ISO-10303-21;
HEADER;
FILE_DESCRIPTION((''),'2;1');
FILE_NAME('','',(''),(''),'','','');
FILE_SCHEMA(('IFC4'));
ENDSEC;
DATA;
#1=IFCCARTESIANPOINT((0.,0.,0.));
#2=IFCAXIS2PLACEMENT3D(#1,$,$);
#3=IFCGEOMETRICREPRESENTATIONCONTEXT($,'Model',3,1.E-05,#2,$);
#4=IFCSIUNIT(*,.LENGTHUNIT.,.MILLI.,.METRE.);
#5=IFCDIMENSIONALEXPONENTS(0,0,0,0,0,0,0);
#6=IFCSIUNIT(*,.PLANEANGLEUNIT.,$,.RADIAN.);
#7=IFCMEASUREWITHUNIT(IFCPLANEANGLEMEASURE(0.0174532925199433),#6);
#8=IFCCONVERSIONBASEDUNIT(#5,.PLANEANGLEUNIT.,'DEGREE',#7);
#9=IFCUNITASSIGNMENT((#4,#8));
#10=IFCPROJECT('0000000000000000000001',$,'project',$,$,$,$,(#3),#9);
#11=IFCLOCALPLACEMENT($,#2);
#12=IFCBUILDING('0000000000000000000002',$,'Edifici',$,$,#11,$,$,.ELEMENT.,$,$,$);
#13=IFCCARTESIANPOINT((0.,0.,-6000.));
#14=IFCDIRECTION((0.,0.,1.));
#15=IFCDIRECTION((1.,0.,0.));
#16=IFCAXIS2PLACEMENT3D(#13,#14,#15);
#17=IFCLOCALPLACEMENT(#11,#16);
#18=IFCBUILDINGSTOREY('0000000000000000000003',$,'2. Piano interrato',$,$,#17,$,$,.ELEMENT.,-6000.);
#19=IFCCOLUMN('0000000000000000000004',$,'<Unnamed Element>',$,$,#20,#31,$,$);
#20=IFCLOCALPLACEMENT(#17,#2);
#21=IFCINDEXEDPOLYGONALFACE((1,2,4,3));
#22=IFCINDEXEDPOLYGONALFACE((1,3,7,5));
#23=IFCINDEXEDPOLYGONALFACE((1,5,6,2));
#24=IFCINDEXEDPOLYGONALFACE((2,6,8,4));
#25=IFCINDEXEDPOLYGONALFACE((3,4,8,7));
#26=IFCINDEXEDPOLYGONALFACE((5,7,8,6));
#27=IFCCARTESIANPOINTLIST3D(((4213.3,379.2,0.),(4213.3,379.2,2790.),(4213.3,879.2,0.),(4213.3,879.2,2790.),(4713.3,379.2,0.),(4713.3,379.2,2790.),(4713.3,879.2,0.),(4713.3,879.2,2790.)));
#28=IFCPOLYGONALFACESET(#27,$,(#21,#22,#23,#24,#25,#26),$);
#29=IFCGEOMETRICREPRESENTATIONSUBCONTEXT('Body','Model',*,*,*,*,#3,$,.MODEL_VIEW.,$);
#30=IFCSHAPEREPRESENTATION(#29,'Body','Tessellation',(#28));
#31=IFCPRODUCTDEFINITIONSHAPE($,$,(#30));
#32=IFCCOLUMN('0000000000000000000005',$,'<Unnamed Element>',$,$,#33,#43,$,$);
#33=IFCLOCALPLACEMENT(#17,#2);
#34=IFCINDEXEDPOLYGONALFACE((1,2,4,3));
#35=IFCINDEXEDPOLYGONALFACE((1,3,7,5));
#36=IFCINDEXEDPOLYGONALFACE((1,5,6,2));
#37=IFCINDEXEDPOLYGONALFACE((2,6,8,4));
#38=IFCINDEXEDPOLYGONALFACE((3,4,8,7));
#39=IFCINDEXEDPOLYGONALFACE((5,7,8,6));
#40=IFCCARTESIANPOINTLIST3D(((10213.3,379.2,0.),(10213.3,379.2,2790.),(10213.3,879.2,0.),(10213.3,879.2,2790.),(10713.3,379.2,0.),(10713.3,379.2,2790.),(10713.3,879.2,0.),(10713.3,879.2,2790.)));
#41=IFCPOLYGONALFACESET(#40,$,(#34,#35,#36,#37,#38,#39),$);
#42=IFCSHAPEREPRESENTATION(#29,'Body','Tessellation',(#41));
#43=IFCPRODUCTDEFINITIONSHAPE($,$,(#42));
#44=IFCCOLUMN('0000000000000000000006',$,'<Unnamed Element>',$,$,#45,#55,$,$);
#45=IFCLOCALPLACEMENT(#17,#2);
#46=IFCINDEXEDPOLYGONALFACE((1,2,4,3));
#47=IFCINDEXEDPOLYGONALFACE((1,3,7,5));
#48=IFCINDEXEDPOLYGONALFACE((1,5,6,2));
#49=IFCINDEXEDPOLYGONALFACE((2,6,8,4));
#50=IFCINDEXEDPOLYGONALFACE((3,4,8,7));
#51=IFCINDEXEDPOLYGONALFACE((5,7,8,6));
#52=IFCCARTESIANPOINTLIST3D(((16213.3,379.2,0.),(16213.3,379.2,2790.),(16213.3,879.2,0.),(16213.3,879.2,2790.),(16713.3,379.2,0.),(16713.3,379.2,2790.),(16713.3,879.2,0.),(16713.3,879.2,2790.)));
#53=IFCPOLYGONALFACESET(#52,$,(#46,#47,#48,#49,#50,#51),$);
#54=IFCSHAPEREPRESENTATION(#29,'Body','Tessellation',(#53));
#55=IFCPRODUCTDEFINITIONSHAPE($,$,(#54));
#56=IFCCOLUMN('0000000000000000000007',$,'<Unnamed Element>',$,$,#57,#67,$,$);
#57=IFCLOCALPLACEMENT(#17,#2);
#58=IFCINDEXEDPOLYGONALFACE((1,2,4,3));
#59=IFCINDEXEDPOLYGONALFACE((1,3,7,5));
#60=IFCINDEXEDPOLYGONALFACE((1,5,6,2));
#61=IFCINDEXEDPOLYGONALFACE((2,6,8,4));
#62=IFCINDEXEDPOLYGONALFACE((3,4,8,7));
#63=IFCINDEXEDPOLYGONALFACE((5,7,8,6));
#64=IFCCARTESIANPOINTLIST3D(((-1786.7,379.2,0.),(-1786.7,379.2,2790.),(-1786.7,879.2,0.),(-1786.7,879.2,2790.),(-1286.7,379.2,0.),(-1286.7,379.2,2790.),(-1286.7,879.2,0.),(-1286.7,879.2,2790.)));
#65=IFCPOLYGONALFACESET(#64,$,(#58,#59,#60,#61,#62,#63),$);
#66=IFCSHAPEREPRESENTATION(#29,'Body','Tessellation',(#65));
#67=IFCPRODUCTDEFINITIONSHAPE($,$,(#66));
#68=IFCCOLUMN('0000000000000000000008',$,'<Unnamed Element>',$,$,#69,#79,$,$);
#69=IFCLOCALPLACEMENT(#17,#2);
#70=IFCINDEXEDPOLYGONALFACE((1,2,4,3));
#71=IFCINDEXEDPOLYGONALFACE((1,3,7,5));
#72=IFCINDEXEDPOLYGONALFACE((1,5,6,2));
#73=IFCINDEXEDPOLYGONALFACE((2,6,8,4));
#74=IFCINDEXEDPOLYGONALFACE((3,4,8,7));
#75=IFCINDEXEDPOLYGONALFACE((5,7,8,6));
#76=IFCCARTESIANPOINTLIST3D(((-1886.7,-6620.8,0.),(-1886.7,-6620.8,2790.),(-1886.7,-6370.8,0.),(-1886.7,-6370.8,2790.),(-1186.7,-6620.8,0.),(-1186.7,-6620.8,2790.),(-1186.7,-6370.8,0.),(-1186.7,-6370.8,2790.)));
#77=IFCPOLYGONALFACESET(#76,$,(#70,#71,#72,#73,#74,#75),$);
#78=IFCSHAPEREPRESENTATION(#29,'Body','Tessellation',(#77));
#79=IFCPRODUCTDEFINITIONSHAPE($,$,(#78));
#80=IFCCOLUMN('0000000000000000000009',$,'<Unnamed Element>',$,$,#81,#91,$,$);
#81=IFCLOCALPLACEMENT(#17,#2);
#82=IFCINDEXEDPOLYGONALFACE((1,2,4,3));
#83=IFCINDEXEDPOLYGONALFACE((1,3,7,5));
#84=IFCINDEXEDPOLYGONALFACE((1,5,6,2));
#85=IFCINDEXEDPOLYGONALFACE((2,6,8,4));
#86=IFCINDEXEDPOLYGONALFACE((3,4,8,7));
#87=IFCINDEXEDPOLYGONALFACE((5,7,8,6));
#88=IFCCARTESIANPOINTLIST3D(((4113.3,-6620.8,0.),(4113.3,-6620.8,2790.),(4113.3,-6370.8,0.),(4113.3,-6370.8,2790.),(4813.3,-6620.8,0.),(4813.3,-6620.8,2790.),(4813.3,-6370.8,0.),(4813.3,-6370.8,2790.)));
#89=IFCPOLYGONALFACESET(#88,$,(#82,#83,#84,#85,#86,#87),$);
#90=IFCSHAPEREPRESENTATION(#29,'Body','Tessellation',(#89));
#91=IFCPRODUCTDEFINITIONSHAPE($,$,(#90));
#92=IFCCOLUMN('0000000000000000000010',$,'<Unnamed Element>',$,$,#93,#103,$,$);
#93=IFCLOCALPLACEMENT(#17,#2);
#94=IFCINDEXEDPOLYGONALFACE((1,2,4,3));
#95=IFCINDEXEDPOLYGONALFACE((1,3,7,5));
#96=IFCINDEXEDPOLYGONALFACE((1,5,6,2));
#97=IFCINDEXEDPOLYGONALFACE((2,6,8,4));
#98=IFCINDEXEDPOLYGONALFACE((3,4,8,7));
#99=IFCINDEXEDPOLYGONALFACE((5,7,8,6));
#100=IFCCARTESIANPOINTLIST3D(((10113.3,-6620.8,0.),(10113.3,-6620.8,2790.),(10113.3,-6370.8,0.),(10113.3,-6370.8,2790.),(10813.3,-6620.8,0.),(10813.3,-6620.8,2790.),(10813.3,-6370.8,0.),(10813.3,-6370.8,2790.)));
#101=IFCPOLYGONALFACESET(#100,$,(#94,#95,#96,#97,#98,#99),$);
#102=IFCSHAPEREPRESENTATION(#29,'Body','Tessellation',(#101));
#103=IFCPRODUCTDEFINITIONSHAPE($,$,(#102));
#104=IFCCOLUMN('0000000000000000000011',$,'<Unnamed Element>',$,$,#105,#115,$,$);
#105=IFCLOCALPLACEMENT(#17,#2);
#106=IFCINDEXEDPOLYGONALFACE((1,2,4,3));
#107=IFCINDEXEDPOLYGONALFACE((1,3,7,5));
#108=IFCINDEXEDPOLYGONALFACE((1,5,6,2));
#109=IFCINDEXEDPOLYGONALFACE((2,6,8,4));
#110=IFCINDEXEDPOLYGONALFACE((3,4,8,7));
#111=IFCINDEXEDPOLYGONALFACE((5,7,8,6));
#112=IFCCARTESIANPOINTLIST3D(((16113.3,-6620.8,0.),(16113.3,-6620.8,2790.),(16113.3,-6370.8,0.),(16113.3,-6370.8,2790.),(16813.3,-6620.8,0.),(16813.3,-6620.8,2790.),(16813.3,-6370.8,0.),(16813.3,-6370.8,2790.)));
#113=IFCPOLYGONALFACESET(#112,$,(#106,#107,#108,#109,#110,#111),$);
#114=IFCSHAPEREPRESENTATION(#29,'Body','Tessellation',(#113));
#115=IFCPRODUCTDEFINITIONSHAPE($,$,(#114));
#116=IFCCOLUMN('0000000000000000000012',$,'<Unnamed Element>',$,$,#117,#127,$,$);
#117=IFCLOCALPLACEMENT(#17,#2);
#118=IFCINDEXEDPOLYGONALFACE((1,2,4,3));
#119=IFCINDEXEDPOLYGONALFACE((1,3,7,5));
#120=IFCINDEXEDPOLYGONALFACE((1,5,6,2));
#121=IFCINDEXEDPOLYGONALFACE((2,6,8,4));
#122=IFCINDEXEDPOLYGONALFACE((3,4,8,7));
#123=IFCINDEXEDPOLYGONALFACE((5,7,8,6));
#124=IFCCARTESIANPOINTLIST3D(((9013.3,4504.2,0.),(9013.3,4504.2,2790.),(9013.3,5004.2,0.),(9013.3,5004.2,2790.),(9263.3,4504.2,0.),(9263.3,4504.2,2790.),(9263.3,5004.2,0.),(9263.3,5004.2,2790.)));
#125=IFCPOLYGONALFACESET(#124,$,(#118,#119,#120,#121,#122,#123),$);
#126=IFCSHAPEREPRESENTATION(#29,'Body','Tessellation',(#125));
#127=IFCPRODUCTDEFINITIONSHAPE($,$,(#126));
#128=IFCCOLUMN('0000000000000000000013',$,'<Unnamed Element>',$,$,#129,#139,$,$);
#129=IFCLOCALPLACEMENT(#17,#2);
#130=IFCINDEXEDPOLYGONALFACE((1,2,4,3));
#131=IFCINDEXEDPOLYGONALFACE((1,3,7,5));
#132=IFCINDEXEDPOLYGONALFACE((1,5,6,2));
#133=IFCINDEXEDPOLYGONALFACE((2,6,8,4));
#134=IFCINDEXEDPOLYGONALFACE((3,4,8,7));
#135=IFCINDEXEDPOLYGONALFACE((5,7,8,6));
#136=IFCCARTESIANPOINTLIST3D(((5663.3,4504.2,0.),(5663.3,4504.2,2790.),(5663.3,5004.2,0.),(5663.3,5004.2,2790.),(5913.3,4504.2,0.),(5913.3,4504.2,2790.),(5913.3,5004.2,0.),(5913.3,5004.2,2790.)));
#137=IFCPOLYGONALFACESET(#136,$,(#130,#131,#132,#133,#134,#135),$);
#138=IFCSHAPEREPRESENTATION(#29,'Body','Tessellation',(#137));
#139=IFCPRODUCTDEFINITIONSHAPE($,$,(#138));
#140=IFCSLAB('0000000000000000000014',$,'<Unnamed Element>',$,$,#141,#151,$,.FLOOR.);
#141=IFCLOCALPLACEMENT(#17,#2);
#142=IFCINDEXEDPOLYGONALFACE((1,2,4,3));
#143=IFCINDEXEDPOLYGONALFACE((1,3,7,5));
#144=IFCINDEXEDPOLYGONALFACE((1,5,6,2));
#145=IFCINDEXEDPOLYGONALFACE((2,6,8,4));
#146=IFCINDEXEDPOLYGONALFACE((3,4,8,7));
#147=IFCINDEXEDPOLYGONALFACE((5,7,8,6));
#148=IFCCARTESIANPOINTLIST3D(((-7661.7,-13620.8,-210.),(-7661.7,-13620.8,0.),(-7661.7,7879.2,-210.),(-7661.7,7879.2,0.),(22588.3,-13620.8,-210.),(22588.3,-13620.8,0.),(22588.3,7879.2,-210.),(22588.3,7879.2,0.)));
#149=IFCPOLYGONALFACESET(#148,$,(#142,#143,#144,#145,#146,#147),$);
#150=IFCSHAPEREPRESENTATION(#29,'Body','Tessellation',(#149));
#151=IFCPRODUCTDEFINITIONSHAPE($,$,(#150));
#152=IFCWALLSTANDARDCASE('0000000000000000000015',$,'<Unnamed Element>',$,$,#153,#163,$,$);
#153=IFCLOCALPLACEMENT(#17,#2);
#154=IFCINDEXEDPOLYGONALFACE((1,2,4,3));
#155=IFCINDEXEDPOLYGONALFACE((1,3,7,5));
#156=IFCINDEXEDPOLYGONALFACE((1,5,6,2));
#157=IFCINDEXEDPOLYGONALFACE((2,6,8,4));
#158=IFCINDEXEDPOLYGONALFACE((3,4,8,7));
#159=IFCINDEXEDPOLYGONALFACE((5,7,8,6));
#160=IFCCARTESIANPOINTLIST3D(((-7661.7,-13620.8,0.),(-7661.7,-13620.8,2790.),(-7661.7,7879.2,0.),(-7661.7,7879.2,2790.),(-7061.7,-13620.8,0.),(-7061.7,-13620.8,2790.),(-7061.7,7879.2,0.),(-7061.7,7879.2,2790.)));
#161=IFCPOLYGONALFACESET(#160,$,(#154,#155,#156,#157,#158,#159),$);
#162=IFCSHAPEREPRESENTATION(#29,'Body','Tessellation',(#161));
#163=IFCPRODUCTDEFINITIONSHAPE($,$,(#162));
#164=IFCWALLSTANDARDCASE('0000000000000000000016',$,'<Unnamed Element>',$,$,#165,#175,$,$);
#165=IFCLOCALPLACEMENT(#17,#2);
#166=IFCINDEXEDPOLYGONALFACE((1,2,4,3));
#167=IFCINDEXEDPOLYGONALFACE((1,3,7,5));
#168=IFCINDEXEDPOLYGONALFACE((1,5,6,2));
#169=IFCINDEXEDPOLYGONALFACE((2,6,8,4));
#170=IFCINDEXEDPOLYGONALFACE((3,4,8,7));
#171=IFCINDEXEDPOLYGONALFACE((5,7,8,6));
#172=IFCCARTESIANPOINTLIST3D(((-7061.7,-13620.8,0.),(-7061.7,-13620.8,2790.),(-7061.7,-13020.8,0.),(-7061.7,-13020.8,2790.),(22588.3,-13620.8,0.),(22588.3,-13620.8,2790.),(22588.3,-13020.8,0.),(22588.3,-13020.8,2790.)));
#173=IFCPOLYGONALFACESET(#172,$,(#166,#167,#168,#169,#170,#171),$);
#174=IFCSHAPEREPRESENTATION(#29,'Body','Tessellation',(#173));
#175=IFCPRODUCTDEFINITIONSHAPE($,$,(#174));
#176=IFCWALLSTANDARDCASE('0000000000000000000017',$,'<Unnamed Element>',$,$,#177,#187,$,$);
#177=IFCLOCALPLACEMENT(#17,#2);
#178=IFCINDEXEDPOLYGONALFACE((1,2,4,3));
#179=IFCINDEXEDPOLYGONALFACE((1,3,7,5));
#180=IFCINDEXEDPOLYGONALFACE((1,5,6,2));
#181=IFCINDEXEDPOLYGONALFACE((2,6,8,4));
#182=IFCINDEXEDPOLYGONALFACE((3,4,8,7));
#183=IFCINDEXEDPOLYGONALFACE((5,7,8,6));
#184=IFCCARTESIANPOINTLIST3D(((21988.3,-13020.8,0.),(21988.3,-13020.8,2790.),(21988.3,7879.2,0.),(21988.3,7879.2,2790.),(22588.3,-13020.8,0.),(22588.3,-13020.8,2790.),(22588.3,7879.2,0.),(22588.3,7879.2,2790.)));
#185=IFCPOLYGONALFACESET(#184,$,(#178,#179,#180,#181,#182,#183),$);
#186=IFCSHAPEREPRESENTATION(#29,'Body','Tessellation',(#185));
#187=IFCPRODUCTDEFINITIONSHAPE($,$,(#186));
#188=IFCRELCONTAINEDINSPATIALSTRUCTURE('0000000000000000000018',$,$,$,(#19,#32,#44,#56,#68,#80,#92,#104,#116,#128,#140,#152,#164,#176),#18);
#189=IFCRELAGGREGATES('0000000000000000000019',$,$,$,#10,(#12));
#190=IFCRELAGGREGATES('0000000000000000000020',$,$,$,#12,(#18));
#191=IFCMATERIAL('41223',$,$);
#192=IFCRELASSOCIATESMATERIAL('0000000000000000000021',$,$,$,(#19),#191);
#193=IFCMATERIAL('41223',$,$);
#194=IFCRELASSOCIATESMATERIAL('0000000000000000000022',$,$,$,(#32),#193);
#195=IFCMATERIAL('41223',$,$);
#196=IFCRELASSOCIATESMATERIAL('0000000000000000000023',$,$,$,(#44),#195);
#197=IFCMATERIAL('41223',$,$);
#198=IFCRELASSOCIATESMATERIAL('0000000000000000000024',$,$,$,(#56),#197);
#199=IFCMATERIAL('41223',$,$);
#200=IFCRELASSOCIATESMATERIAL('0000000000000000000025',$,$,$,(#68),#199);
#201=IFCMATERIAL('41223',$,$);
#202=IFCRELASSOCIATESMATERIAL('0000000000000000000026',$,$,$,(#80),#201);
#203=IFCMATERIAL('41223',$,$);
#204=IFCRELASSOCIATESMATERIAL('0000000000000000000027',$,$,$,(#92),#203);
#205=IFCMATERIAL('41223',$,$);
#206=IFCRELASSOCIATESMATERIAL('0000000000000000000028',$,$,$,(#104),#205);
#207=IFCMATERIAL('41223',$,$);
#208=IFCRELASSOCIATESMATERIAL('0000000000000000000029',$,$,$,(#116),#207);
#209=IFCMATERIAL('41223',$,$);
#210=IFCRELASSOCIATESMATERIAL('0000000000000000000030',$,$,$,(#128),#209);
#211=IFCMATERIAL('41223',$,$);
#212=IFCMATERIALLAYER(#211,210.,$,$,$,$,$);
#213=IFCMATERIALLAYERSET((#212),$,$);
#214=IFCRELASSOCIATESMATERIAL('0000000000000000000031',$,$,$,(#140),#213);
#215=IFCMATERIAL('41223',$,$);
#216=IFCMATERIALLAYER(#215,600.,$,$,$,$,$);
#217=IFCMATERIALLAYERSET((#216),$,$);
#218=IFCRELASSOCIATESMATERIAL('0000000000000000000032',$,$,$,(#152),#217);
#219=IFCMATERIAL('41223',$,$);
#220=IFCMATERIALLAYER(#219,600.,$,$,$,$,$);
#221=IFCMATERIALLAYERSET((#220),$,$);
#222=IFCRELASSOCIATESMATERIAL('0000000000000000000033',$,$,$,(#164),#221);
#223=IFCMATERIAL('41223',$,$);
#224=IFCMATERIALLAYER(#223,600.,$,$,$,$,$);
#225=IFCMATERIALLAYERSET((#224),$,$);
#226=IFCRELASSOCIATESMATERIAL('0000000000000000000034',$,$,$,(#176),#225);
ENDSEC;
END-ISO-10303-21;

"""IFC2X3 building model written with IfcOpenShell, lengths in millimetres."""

from ifc_helpers import new_model, entity, si_unit, converted_unit, frame, frame_2d, origin, origin_with_axes, place, context, subcontext, project, spatial, rectangle, extrude, material, layer, layer_set, layer_usage, element, save


model = new_model("IFC2X3")

# Units and contexts
model_context = context("Model", 3, precision=1e-05, world=origin())
body_context = subcontext(model_context, "Body", "Model", "MODEL_VIEW")
ifc_project = project(units=[si_unit("LENGTHUNIT", "METRE", prefix="MILLI"), converted_unit("PLANEANGLEUNIT", "DEGREE", entity("IfcPlaneAngleMeasure", 0.0174532925199433), si_unit("PLANEANGLEUNIT", "RADIAN"), dimensions=[0, 0, 0, 0, 0, 0, 0])], contexts=[model_context])

# Building, storey
building_placement = place(None, origin())
building = spatial("IfcBuilding", under=ifc_project, at=building_placement, Name="Edifici", CompositionType="ELEMENT")
storey_placement = place(building_placement, frame((0.0, 0.0, -6000.0), z_axis=(0.0, 0.0, 1.0), x_axis=(1.0, 0.0, 0.0)))
storey = spatial("IfcBuildingStorey", under=building, at=storey_placement, Name="2. Piano interrato", CompositionType="ELEMENT", Elevation=-6000.0)

# Columns
ifc_material_1 = material(Name="41223")
column_1_placement = place(storey_placement, frame((4213.3, 379.2, 0.0), z_axis=(0.0, 0.0, 1.0), x_axis=(1.0, 0.0, 0.0)))
element("IfcColumn", 1, at=column_1_placement, inside=storey, material=ifc_material_1, Name="<Unnamed Element>", context=body_context, shape_type="SweptSolid", body=[
    extrude(rectangle(XDim=500.0, YDim=500.0, at=frame_2d((250.0, 250.0), x_axis=(1.0, 0.0))), origin_with_axes(), (0.0, 0.0, 1.0), 2790.0),
])
ifc_material_2 = material(Name="41223")
column_2_placement = place(storey_placement, frame((10213.3, 379.2, 0.0), z_axis=(0.0, 0.0, 1.0), x_axis=(1.0, 0.0, 0.0)))
element("IfcColumn", 2, at=column_2_placement, inside=storey, material=ifc_material_2, Name="<Unnamed Element>", context=body_context, shape_type="SweptSolid", body=[
    extrude(rectangle(XDim=500.0, YDim=500.0, at=frame_2d((250.0, 250.0), x_axis=(1.0, 0.0))), origin_with_axes(), (0.0, 0.0, 1.0), 2790.0),
])
ifc_material_3 = material(Name="41223")
column_3_placement = place(storey_placement, frame((16213.3, 379.2, 0.0), z_axis=(0.0, 0.0, 1.0), x_axis=(1.0, 0.0, 0.0)))
element("IfcColumn", 3, at=column_3_placement, inside=storey, material=ifc_material_3, Name="<Unnamed Element>", context=body_context, shape_type="SweptSolid", body=[
    extrude(rectangle(XDim=500.0, YDim=500.0, at=frame_2d((250.0, 250.0), x_axis=(1.0, 0.0))), origin_with_axes(), (0.0, 0.0, 1.0), 2790.0),
])
ifc_material_4 = material(Name="41223")
column_4_placement = place(storey_placement, frame((-1786.7, 379.2, 0.0), z_axis=(0.0, 0.0, 1.0), x_axis=(1.0, 0.0, 0.0)))
element("IfcColumn", 4, at=column_4_placement, inside=storey, material=ifc_material_4, Name="<Unnamed Element>", context=body_context, shape_type="SweptSolid", body=[
    extrude(rectangle(XDim=500.0, YDim=500.0, at=frame_2d((250.0, 250.0), x_axis=(1.0, 0.0))), origin_with_axes(), (0.0, 0.0, 1.0), 2790.0),
])
ifc_material_5 = material(Name="41223")
column_5_placement = place(storey_placement, frame((-1186.7, -6620.8, 0.0), z_axis=(0.0, 0.0, 1.0), x_axis=(1.0, 0.0, 0.0)))
element("IfcColumn", 5, at=column_5_placement, inside=storey, material=ifc_material_5, Name="<Unnamed Element>", context=body_context, shape_type="SweptSolid", body=[
    extrude(rectangle(XDim=250.0, YDim=700.0, at=frame_2d((-350.0, 125.0), x_axis=(0.0, 1.0))), origin_with_axes(), (0.0, 0.0, 1.0), 2790.0),
])
ifc_material_6 = material(Name="41223")
column_6_placement = place(storey_placement, frame((4813.3, -6620.8, 0.0), z_axis=(0.0, 0.0, 1.0), x_axis=(1.0, 0.0, 0.0)))
element("IfcColumn", 6, at=column_6_placement, inside=storey, material=ifc_material_6, Name="<Unnamed Element>", context=body_context, shape_type="SweptSolid", body=[
    extrude(rectangle(XDim=250.0, YDim=700.0, at=frame_2d((-350.0, 125.0), x_axis=(0.0, 1.0))), origin_with_axes(), (0.0, 0.0, 1.0), 2790.0),
])
ifc_material_7 = material(Name="41223")
column_7_placement = place(storey_placement, frame((10813.3, -6620.8, 0.0), z_axis=(0.0, 0.0, 1.0), x_axis=(1.0, 0.0, 0.0)))
element("IfcColumn", 7, at=column_7_placement, inside=storey, material=ifc_material_7, Name="<Unnamed Element>", context=body_context, shape_type="SweptSolid", body=[
    extrude(rectangle(XDim=250.0, YDim=700.0, at=frame_2d((-350.0, 125.0), x_axis=(0.0, 1.0))), origin_with_axes(), (0.0, 0.0, 1.0), 2790.0),
])
ifc_material_8 = material(Name="41223")
column_8_placement = place(storey_placement, frame((16813.3, -6620.8, 0.0), z_axis=(0.0, 0.0, 1.0), x_axis=(1.0, 0.0, 0.0)))
element("IfcColumn", 8, at=column_8_placement, inside=storey, material=ifc_material_8, Name="<Unnamed Element>", context=body_context, shape_type="SweptSolid", body=[
    extrude(rectangle(XDim=250.0, YDim=700.0, at=frame_2d((-350.0, 125.0), x_axis=(0.0, 1.0))), origin_with_axes(), (0.0, 0.0, 1.0), 2790.0),
])
ifc_material_9 = material(Name="41223")
column_9_placement = place(storey_placement, frame((9263.3, 5004.2, 0.0), z_axis=(0.0, 0.0, 1.0), x_axis=(1.0, 0.0, 0.0)))
element("IfcColumn", 9, at=column_9_placement, inside=storey, material=ifc_material_9, Name="<Unnamed Element>", context=body_context, shape_type="SweptSolid", body=[
    extrude(rectangle(XDim=250.0, YDim=500.0, at=frame_2d((-125.0, -250.0), x_axis=(-1.0, 0.0))), origin_with_axes(), (0.0, 0.0, 1.0), 2790.0),
])
ifc_material_10 = material(Name="41223")
column_10_placement = place(storey_placement, frame((5913.3, 5004.2, 0.0), z_axis=(0.0, 0.0, 1.0), x_axis=(1.0, 0.0, 0.0)))
element("IfcColumn", 10, at=column_10_placement, inside=storey, material=ifc_material_10, Name="<Unnamed Element>", context=body_context, shape_type="SweptSolid", body=[
    extrude(rectangle(XDim=250.0, YDim=500.0, at=frame_2d((-125.0, -250.0), x_axis=(-1.0, 0.0))), origin_with_axes(), (0.0, 0.0, 1.0), 2790.0),
])

# Slab
ifc_material_11 = material(Name="41223")
ifc_layer_1 = layer(ifc_material_11, 210.0)
ifc_layer_set_1 = layer_set([ifc_layer_1])
ifc_layer_usage_1 = layer_usage(ifc_layer_set_1, "AXIS3", "POSITIVE", 0.0)
slab_placement = place(storey_placement, frame((-7661.7, -13620.8, -210.0), z_axis=(0.0, 0.0, 1.0), x_axis=(1.0, 0.0, 0.0)))
element("IfcSlab", 11, at=slab_placement, inside=storey, material=ifc_layer_usage_1, Name="<Unnamed Element>", PredefinedType="FLOOR", context=body_context, shape_type="SweptSolid", body=[
    extrude(rectangle(XDim=30250.0, YDim=21500.0, at=frame_2d((15125.0, 10750.0), x_axis=(1.0, 0.0))), origin_with_axes(), (0.0, 0.0, 1.0), 210.0),
])

# Walls
ifc_material_12 = material(Name="41223")
ifc_layer_2 = layer(ifc_material_12, 600.0)
ifc_layer_set_2 = layer_set([ifc_layer_2])
ifc_layer_usage_2 = layer_usage(ifc_layer_set_2, "AXIS2", "POSITIVE", 0.0)
wall_1_placement = place(storey_placement, frame((-7661.7, 7879.2, 0.0), z_axis=(0.0, 0.0, 1.0), x_axis=(0.0, -1.0, 0.0)))
element("IfcWallStandardCase", 12, at=wall_1_placement, inside=storey, material=ifc_layer_usage_2, Name="<Unnamed Element>", context=body_context, shape_type="SweptSolid", body=[
    extrude(rectangle(XDim=21500.0, YDim=600.0, at=frame_2d((10750.0, 300.0), x_axis=(1.0, 0.0))), origin_with_axes(), (0.0, 0.0, 1.0), 2790.0),
])
ifc_material_13 = material(Name="41223")
ifc_layer_3 = layer(ifc_material_13, 600.0)
ifc_layer_set_3 = layer_set([ifc_layer_3])
ifc_layer_usage_3 = layer_usage(ifc_layer_set_3, "AXIS2", "POSITIVE", 0.0)
wall_2_placement = place(storey_placement, frame((-7061.7, -13620.8, 0.0), z_axis=(0.0, 0.0, 1.0), x_axis=(1.0, 0.0, 0.0)))
element("IfcWallStandardCase", 13, at=wall_2_placement, inside=storey, material=ifc_layer_usage_3, Name="<Unnamed Element>", context=body_context, shape_type="SweptSolid", body=[
    extrude(rectangle(XDim=29650.0, YDim=600.0, at=frame_2d((14825.0, 300.0), x_axis=(1.0, 0.0))), origin_with_axes(), (0.0, 0.0, 1.0), 2790.0),
])
ifc_material_14 = material(Name="41223")
ifc_layer_4 = layer(ifc_material_14, 600.0)
ifc_layer_set_4 = layer_set([ifc_layer_4])
ifc_layer_usage_4 = layer_usage(ifc_layer_set_4, "AXIS2", "POSITIVE", 0.0)
wall_3_placement = place(storey_placement, frame((22588.3, -13020.8, 0.0), z_axis=(0.0, 0.0, 1.0), x_axis=(0.0, 1.0, 0.0)))
element("IfcWallStandardCase", 14, at=wall_3_placement, inside=storey, material=ifc_layer_usage_4, Name="<Unnamed Element>", context=body_context, shape_type="SweptSolid", body=[
    extrude(rectangle(XDim=20900.0, YDim=600.0, at=frame_2d((10450.0, 300.0), x_axis=(1.0, 0.0))), origin_with_axes(), (0.0, 0.0, 1.0), 2790.0),
])

save(model, "model.ifc")
